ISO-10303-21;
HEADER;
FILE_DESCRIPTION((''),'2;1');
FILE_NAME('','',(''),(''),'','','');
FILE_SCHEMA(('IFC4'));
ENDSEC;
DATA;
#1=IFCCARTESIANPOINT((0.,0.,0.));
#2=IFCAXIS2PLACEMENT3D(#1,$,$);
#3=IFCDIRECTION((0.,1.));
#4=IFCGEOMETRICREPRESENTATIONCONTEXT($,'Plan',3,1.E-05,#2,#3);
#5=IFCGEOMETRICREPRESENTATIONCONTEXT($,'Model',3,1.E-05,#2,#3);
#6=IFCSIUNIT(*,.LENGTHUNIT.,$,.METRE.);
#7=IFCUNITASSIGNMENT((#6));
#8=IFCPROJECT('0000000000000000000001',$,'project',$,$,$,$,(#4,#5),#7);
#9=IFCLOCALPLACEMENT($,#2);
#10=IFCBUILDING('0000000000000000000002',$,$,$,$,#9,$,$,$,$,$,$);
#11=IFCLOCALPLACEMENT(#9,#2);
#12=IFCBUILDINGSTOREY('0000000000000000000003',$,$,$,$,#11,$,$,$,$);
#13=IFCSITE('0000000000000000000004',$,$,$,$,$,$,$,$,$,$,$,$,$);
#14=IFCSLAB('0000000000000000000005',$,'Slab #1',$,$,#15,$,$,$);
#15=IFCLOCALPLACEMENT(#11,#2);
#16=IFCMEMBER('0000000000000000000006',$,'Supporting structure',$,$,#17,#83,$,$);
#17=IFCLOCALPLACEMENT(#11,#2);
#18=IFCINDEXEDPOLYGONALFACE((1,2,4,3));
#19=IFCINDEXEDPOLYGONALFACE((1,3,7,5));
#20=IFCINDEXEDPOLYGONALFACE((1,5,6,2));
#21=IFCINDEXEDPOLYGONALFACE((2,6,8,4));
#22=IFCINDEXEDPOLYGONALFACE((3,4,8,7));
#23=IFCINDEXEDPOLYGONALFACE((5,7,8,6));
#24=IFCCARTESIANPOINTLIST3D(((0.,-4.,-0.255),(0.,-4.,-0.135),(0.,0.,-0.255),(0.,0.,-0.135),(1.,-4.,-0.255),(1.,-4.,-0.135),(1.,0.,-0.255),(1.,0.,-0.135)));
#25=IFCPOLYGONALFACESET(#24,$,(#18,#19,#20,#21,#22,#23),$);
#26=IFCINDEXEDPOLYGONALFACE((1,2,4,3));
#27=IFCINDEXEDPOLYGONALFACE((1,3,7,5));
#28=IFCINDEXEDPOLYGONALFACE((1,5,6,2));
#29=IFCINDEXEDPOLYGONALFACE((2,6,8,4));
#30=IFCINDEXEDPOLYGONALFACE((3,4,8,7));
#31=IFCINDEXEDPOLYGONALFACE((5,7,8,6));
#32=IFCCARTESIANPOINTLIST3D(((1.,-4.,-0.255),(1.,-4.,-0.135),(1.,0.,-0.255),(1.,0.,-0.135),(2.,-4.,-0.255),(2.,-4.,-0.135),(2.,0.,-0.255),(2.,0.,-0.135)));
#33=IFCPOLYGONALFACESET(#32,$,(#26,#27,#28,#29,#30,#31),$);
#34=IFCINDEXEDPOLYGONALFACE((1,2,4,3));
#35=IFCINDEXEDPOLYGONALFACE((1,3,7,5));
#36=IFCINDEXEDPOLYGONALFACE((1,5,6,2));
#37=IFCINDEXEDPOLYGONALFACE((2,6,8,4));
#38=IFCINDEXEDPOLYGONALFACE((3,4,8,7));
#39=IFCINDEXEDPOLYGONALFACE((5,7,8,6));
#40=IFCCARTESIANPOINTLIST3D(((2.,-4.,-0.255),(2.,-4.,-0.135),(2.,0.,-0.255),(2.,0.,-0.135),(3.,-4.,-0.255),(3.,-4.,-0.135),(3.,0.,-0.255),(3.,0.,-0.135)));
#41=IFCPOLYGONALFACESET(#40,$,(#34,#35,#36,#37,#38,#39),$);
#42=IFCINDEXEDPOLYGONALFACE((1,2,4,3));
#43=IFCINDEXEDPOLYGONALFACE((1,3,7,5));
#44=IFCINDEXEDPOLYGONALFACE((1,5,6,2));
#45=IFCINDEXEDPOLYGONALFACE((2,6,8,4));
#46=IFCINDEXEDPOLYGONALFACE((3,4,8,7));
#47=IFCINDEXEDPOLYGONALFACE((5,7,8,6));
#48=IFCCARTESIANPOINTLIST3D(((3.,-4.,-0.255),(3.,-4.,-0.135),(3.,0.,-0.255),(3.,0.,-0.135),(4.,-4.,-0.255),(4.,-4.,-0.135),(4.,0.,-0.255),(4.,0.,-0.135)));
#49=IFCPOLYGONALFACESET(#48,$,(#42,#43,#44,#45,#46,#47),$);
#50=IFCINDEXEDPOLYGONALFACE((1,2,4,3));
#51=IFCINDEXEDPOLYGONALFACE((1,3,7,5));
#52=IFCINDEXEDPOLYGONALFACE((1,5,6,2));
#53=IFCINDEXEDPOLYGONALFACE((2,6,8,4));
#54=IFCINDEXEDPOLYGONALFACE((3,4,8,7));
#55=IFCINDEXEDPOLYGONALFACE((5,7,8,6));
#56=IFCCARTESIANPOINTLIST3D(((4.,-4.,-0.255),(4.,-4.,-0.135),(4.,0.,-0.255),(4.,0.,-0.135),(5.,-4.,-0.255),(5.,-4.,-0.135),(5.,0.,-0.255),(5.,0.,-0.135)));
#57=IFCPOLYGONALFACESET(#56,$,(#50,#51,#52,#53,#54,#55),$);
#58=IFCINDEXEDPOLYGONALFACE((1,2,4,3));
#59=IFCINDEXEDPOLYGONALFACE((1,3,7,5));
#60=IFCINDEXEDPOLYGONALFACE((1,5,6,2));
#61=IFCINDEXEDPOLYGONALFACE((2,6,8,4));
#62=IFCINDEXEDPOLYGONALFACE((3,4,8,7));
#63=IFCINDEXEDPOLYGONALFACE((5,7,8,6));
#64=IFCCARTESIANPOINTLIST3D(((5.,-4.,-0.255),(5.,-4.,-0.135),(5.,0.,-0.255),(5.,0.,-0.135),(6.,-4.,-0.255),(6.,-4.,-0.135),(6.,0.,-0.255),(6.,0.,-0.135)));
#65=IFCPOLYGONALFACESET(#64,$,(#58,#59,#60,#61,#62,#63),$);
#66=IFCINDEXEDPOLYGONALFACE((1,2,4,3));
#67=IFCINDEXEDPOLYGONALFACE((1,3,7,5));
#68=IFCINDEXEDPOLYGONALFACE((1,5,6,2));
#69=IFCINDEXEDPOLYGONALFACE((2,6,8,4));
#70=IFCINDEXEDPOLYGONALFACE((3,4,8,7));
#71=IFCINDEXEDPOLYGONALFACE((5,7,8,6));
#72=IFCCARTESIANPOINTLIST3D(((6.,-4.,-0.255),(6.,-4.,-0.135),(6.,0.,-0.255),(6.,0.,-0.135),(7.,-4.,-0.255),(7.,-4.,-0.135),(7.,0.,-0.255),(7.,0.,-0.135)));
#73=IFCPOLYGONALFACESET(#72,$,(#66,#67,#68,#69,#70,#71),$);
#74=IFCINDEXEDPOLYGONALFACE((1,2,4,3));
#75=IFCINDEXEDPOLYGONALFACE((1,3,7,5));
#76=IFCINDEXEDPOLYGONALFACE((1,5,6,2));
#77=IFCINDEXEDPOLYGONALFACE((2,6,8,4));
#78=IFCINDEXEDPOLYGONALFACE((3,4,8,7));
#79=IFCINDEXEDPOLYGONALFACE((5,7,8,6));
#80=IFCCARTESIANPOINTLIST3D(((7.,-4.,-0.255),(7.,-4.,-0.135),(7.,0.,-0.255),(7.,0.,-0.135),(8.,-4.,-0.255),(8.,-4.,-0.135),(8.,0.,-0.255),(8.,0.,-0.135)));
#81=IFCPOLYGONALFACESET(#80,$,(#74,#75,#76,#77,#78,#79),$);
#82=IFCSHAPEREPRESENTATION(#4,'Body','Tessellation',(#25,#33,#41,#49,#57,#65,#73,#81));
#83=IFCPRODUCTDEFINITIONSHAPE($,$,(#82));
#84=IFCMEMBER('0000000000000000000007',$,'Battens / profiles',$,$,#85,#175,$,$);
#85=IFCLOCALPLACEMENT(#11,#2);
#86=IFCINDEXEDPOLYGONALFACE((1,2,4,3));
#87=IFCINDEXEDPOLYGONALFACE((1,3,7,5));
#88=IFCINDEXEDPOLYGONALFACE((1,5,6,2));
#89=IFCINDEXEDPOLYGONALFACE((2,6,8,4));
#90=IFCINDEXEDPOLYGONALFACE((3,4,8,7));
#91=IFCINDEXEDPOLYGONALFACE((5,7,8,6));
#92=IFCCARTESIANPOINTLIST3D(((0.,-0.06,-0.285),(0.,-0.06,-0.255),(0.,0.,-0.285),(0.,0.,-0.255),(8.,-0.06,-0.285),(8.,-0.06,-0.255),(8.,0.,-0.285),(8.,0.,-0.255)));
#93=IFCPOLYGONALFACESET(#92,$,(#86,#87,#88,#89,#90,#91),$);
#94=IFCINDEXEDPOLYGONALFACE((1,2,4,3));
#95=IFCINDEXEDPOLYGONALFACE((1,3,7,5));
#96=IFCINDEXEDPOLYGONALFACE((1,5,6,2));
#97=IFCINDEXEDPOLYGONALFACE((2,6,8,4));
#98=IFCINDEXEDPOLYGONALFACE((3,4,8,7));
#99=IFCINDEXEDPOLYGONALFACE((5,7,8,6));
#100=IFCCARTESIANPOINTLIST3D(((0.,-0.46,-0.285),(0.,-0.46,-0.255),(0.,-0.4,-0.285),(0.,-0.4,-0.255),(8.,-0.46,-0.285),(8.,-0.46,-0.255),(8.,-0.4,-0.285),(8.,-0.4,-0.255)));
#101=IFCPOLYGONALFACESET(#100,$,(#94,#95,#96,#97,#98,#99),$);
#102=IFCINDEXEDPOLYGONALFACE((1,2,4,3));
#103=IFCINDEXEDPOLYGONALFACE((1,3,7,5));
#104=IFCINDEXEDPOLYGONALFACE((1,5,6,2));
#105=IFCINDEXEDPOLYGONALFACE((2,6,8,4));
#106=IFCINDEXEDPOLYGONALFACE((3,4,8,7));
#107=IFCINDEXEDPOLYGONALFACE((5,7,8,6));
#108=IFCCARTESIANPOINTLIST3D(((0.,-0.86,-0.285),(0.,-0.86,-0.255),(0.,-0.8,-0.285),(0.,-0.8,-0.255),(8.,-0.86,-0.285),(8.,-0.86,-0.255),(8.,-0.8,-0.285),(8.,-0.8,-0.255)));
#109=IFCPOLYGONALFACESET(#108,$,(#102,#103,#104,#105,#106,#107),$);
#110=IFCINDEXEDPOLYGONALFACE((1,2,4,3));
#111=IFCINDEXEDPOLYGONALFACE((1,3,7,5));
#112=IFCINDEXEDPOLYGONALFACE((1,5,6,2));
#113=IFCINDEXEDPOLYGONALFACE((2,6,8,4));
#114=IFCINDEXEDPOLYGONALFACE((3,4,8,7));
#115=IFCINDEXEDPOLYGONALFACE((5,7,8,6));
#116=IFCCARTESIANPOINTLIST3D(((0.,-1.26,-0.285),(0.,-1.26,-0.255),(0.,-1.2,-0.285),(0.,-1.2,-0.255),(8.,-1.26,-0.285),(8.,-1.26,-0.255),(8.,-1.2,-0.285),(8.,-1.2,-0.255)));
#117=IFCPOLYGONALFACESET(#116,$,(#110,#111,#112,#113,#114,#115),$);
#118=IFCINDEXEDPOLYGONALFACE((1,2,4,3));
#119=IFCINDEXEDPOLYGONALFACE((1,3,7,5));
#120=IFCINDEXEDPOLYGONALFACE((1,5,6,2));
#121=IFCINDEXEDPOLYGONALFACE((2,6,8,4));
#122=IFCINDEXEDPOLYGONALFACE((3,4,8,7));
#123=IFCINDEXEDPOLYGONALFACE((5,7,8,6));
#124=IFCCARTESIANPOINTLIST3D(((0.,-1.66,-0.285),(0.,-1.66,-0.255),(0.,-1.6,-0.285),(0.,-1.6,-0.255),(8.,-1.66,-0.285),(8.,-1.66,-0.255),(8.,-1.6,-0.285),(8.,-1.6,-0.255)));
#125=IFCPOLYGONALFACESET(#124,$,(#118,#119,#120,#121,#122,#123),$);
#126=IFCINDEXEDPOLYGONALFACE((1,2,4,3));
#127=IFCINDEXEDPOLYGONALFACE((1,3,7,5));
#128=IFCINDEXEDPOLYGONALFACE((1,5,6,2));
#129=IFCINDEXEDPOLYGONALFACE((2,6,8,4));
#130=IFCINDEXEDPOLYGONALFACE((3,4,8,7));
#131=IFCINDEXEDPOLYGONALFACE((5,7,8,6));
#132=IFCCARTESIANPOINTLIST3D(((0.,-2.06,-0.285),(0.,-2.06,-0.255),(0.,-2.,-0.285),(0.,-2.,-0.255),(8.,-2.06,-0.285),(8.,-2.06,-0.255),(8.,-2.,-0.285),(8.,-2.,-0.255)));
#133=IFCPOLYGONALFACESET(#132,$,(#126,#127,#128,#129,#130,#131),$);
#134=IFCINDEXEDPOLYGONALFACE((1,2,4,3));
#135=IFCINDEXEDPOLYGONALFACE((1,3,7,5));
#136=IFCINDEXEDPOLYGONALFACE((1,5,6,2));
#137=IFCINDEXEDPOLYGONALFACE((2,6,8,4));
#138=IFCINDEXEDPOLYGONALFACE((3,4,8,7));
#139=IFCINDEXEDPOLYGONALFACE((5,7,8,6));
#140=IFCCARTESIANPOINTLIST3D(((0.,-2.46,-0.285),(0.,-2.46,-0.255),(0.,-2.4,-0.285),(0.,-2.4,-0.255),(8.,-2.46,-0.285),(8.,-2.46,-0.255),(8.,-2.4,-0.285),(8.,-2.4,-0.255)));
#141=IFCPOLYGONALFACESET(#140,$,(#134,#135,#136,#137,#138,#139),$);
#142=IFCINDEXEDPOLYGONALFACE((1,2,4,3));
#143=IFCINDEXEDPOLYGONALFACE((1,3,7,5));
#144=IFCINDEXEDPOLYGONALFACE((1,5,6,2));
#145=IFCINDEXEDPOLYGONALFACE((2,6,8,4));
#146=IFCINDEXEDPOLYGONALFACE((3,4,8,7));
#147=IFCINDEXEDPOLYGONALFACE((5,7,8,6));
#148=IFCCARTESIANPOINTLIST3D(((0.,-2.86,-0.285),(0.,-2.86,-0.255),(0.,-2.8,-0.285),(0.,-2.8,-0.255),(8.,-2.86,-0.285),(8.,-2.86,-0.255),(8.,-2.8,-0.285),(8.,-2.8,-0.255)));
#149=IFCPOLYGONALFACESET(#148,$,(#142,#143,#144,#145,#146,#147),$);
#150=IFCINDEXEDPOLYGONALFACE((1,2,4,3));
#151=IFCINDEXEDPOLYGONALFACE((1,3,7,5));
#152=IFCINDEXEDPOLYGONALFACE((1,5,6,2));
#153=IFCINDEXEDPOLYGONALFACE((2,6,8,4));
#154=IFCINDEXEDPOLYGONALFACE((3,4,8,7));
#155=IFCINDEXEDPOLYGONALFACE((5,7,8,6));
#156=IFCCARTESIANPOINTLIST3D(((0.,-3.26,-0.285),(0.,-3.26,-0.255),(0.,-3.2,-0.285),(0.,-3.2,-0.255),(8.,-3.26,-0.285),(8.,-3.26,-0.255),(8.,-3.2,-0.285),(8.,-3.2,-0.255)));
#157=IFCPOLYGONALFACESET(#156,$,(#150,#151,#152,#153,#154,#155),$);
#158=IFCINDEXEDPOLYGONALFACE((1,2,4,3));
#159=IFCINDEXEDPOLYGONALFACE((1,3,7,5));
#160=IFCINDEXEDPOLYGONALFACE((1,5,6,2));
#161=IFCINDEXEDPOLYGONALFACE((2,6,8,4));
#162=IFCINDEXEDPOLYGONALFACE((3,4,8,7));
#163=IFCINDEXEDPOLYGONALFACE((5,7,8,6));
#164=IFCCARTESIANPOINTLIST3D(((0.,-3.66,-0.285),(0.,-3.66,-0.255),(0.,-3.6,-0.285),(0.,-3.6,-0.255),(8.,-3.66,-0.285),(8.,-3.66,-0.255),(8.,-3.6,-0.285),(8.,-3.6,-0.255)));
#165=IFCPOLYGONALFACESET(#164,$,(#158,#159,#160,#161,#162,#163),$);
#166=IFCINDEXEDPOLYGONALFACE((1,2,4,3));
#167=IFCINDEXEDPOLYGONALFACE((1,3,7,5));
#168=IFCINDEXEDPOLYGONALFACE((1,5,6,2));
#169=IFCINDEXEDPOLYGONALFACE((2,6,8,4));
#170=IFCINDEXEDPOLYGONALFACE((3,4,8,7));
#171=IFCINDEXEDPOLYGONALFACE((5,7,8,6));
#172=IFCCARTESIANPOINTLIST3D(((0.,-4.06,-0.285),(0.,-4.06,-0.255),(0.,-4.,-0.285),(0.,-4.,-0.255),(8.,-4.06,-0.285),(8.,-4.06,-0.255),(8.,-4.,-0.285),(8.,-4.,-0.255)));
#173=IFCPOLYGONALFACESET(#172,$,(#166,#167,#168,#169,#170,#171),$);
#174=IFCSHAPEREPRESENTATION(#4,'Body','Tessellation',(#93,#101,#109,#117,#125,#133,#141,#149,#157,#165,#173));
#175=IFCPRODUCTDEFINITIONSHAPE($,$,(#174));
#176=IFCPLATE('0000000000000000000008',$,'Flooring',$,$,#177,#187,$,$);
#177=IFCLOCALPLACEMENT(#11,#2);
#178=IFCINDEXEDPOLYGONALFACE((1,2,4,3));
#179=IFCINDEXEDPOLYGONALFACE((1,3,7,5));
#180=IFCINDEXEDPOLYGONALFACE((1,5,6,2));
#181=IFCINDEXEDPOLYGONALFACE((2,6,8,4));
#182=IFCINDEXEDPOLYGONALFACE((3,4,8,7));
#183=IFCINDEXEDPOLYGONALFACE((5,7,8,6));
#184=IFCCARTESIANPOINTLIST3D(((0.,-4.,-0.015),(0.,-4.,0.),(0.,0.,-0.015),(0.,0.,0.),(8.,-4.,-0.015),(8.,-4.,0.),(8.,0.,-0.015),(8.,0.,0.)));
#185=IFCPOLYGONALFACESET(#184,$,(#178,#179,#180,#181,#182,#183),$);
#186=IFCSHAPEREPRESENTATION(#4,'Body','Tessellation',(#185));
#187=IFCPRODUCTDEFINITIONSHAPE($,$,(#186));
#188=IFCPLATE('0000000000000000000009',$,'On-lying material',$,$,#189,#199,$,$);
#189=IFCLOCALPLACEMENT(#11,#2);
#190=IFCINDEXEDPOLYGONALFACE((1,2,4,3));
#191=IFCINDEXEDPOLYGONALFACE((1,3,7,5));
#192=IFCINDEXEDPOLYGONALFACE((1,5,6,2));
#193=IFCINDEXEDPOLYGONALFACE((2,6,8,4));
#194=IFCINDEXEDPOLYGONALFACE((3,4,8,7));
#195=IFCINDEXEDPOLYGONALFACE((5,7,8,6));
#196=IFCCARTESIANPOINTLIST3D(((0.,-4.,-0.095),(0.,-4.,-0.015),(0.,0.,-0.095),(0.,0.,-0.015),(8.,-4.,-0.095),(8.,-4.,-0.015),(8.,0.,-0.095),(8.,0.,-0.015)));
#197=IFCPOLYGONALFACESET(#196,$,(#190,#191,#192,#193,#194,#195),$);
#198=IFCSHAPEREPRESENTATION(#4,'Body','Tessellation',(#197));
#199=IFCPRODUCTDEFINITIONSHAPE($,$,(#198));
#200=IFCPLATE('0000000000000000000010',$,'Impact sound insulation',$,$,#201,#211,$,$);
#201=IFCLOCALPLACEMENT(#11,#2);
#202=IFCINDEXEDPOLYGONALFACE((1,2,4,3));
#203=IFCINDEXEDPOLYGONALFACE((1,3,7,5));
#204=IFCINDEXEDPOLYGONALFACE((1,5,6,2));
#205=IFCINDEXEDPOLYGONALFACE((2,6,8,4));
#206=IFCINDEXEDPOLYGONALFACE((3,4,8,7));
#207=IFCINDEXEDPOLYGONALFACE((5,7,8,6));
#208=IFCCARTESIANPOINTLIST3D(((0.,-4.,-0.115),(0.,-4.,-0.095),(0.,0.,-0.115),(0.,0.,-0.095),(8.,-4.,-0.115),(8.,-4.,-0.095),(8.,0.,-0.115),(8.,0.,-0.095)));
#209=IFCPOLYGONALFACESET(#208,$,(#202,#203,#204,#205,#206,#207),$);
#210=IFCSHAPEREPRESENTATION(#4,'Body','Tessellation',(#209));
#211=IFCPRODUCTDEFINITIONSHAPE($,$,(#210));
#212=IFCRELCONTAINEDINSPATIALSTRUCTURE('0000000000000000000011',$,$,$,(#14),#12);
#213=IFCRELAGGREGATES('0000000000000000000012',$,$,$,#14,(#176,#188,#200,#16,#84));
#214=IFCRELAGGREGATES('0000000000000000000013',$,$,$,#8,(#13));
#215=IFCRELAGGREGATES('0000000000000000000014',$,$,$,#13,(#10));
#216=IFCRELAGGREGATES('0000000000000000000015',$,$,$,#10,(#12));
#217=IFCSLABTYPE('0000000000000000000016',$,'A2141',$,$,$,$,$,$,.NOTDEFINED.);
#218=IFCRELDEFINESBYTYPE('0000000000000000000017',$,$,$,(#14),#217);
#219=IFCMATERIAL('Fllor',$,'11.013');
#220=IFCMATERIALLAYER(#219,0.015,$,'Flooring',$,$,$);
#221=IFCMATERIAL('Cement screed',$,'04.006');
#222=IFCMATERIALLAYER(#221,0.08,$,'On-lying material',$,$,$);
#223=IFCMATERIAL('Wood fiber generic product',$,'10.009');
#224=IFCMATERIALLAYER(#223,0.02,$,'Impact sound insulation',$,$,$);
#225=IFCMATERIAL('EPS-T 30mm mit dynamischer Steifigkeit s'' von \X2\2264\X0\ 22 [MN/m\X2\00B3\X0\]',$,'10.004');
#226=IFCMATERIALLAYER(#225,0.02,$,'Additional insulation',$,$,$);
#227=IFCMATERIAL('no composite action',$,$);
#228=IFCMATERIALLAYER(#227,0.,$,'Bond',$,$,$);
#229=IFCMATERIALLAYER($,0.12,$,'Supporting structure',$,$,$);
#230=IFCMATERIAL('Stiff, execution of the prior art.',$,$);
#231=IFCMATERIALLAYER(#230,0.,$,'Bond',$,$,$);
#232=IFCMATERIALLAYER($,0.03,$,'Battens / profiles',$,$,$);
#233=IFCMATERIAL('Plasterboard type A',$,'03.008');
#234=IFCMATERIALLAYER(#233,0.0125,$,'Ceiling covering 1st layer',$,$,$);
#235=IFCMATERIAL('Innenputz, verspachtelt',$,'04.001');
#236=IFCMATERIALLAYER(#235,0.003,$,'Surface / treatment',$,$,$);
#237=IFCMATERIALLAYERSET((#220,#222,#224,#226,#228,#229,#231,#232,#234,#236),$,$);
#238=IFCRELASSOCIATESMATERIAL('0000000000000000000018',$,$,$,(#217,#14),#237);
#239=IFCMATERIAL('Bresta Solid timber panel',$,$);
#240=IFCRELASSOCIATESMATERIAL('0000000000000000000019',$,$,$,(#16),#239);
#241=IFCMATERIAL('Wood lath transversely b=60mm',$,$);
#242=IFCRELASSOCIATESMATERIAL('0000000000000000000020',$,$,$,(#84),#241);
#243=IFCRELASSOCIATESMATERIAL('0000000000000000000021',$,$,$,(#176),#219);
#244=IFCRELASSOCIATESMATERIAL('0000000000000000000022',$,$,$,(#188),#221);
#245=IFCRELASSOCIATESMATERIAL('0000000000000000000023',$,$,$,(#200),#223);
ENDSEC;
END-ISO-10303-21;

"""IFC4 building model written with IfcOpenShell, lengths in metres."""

from ifc_helpers import new_model, si_unit, direction, frame, frame_2d, origin, origin_with_axes, place, context, project, spatial, rectangle, extrude, material, layer, layer_set, type_object, element, aggregate, save


model = new_model("IFC4")

# Units and contexts
plan_context = context("Plan", 3, precision=1e-05, world=origin(), true_north=direction((0.0, 1.0)))
model_context = context("Model", 3, precision=1e-05, world=origin(), true_north=direction((0.0, 1.0)))
ifc_project = project(units=[si_unit("LENGTHUNIT", "METRE")], contexts=[plan_context, model_context])

# Site, building, storey
site = spatial("IfcSite", under=ifc_project)
building_placement = place(None, origin())
building = spatial("IfcBuilding", under=site, at=building_placement)
storey_placement = place(building_placement, origin())
storey = spatial("IfcBuildingStorey", under=building, at=storey_placement)

# Slab, members, plates
ifc_material_1 = material(Name="Fllor", Category="11.013")
ifc_layer_1 = layer(ifc_material_1, 0.015, Name="Flooring")
ifc_material_2 = material(Name="Cement screed", Category="04.006")
ifc_layer_2 = layer(ifc_material_2, 0.08, Name="On-lying material")
ifc_material_3 = material(Name="Wood fiber generic product", Category="10.009")
ifc_layer_3 = layer(ifc_material_3, 0.02, Name="Impact sound insulation")
ifc_material_4 = material(Name="EPS-T 30mm mit dynamischer Steifigkeit s' von ≤ 22 [MN/m³]", Category="10.004")
ifc_layer_4 = layer(ifc_material_4, 0.02, Name="Additional insulation")
ifc_material_5 = material(Name="no composite action")
ifc_layer_5 = layer(ifc_material_5, 0.0, Name="Bond")
ifc_layer_6 = layer(None, 0.12, Name="Supporting structure")
ifc_material_6 = material(Name="Stiff, execution of the prior art.")
ifc_layer_7 = layer(ifc_material_6, 0.0, Name="Bond")
ifc_layer_8 = layer(None, 0.03, Name="Battens / profiles")
ifc_material_7 = material(Name="Plasterboard type A", Category="03.008")
ifc_layer_9 = layer(ifc_material_7, 0.0125, Name="Ceiling covering 1st layer")
ifc_material_8 = material(Name="Innenputz, verspachtelt", Category="04.001")
ifc_layer_10 = layer(ifc_material_8, 0.003, Name="Surface / treatment")
ifc_layer_set = layer_set([ifc_layer_1, ifc_layer_2, ifc_layer_3, ifc_layer_4, ifc_layer_5, ifc_layer_6, ifc_layer_7, ifc_layer_8, ifc_layer_9, ifc_layer_10])
slab_type = type_object("IfcSlabType", Name="A2141", PredefinedType="NOTDEFINED", material=ifc_layer_set)
slab_placement = place(None, frame((0.0, 0.0, 0.0), z_axis=(0.0, 0.0, -1.0), x_axis=(1.0, 0.0, 0.0)))
slab = element("IfcSlab", 1, at=slab_placement, inside=storey, type_object=slab_type, material=ifc_layer_set, Name="Slab #1")
ifc_material_9 = material(Name="Bresta Solid timber panel")
member_1_placement = place(slab_placement, origin())
member_1 = element("IfcMember", 2, at=member_1_placement, material=ifc_material_9, Name="Supporting structure", context=plan_context, shape_type="SweptSolid", body=[
    extrude(rectangle(XDim=1.0, YDim=0.12, at=frame_2d((0.5, 0.06), x_axis=(1.0, 0.0))), frame((0.0, 4.0, 0.135), z_axis=(0.0, -1.0, 0.0), x_axis=(1.0, 0.0, 0.0)), (0.0, 0.0, 1.0), 4.0),
    extrude(rectangle(XDim=1.0, YDim=0.12, at=frame_2d((0.5, 0.06), x_axis=(1.0, 0.0))), frame((1.0, 4.0, 0.135), z_axis=(0.0, -1.0, 0.0), x_axis=(1.0, 0.0, 0.0)), (0.0, 0.0, 1.0), 4.0),
    extrude(rectangle(XDim=1.0, YDim=0.12, at=frame_2d((0.5, 0.06), x_axis=(1.0, 0.0))), frame((2.0, 4.0, 0.135), z_axis=(0.0, -1.0, 0.0), x_axis=(1.0, 0.0, 0.0)), (0.0, 0.0, 1.0), 4.0),
    extrude(rectangle(XDim=1.0, YDim=0.12, at=frame_2d((0.5, 0.06), x_axis=(1.0, 0.0))), frame((3.0, 4.0, 0.135), z_axis=(0.0, -1.0, 0.0), x_axis=(1.0, 0.0, 0.0)), (0.0, 0.0, 1.0), 4.0),
    extrude(rectangle(XDim=1.0, YDim=0.12, at=frame_2d((0.5, 0.06), x_axis=(1.0, 0.0))), frame((4.0, 4.0, 0.135), z_axis=(0.0, -1.0, 0.0), x_axis=(1.0, 0.0, 0.0)), (0.0, 0.0, 1.0), 4.0),
    extrude(rectangle(XDim=1.0, YDim=0.12, at=frame_2d((0.5, 0.06), x_axis=(1.0, 0.0))), frame((5.0, 4.0, 0.135), z_axis=(0.0, -1.0, 0.0), x_axis=(1.0, 0.0, 0.0)), (0.0, 0.0, 1.0), 4.0),
    extrude(rectangle(XDim=1.0, YDim=0.12, at=frame_2d((0.5, 0.06), x_axis=(1.0, 0.0))), frame((6.0, 4.0, 0.135), z_axis=(0.0, -1.0, 0.0), x_axis=(1.0, 0.0, 0.0)), (0.0, 0.0, 1.0), 4.0),
    extrude(rectangle(XDim=1.0, YDim=0.12, at=frame_2d((0.5, 0.06), x_axis=(1.0, 0.0))), frame((7.0, 4.0, 0.135), z_axis=(0.0, -1.0, 0.0), x_axis=(1.0, 0.0, 0.0)), (0.0, 0.0, 1.0), 4.0),
])
ifc_material_10 = material(Name="Wood lath transversely b=60mm")
member_2_placement = place(slab_placement, origin())
member_2 = element("IfcMember", 3, at=member_2_placement, material=ifc_material_10, Name="Battens / profiles", context=plan_context, shape_type="SweptSolid", body=[
    extrude(rectangle(XDim=0.06, YDim=0.03, at=frame_2d((0.03, 0.015), x_axis=(1.0, 0.0))), frame((0.0, 0.0, 0.255), z_axis=(1.0, 0.0, 0.0), x_axis=(0.0, 1.0, 0.0)), (0.0, 0.0, 1.0), 8.0),
    extrude(rectangle(XDim=0.06, YDim=0.03, at=frame_2d((0.03, 0.015), x_axis=(1.0, 0.0))), frame((0.0, 0.4, 0.255), z_axis=(1.0, 0.0, 0.0), x_axis=(0.0, 1.0, 0.0)), (0.0, 0.0, 1.0), 8.0),
    extrude(rectangle(XDim=0.06, YDim=0.03, at=frame_2d((0.03, 0.015), x_axis=(1.0, 0.0))), frame((0.0, 0.8, 0.255), z_axis=(1.0, 0.0, 0.0), x_axis=(0.0, 1.0, 0.0)), (0.0, 0.0, 1.0), 8.0),
    extrude(rectangle(XDim=0.06, YDim=0.03, at=frame_2d((0.03, 0.015), x_axis=(1.0, 0.0))), frame((0.0, 1.2, 0.255), z_axis=(1.0, 0.0, 0.0), x_axis=(0.0, 1.0, 0.0)), (0.0, 0.0, 1.0), 8.0),
    extrude(rectangle(XDim=0.06, YDim=0.03, at=frame_2d((0.03, 0.015), x_axis=(1.0, 0.0))), frame((0.0, 1.6, 0.255), z_axis=(1.0, 0.0, 0.0), x_axis=(0.0, 1.0, 0.0)), (0.0, 0.0, 1.0), 8.0),
    extrude(rectangle(XDim=0.06, YDim=0.03, at=frame_2d((0.03, 0.015), x_axis=(1.0, 0.0))), frame((0.0, 2.0, 0.255), z_axis=(1.0, 0.0, 0.0), x_axis=(0.0, 1.0, 0.0)), (0.0, 0.0, 1.0), 8.0),
    extrude(rectangle(XDim=0.06, YDim=0.03, at=frame_2d((0.03, 0.015), x_axis=(1.0, 0.0))), frame((0.0, 2.4, 0.255), z_axis=(1.0, 0.0, 0.0), x_axis=(0.0, 1.0, 0.0)), (0.0, 0.0, 1.0), 8.0),
    extrude(rectangle(XDim=0.06, YDim=0.03, at=frame_2d((0.03, 0.015), x_axis=(1.0, 0.0))), frame((0.0, 2.8, 0.255), z_axis=(1.0, 0.0, 0.0), x_axis=(0.0, 1.0, 0.0)), (0.0, 0.0, 1.0), 8.0),
    extrude(rectangle(XDim=0.06, YDim=0.03, at=frame_2d((0.03, 0.015), x_axis=(1.0, 0.0))), frame((0.0, 3.2, 0.255), z_axis=(1.0, 0.0, 0.0), x_axis=(0.0, 1.0, 0.0)), (0.0, 0.0, 1.0), 8.0),
    extrude(rectangle(XDim=0.06, YDim=0.03, at=frame_2d((0.03, 0.015), x_axis=(1.0, 0.0))), frame((0.0, 3.6, 0.255), z_axis=(1.0, 0.0, 0.0), x_axis=(0.0, 1.0, 0.0)), (0.0, 0.0, 1.0), 8.0),
    extrude(rectangle(XDim=0.06, YDim=0.03, at=frame_2d((0.03, 0.015), x_axis=(1.0, 0.0))), frame((0.0, 4.0, 0.255), z_axis=(1.0, 0.0, 0.0), x_axis=(0.0, 1.0, 0.0)), (0.0, 0.0, 1.0), 8.0),
])
plate_1_placement = place(slab_placement, origin())
plate_1 = element("IfcPlate", 4, at=plate_1_placement, material=ifc_material_1, Name="Flooring", context=plan_context, shape_type="SweptSolid", body=[
    extrude(rectangle(XDim=8.0, YDim=4.0, at=frame_2d((4.0, 2.0), x_axis=(1.0, 0.0))), origin_with_axes(), (0.0, 0.0, 1.0), 0.015),
])
plate_2_placement = place(slab_placement, origin())
plate_2 = element("IfcPlate", 5, at=plate_2_placement, material=ifc_material_2, Name="On-lying material", context=plan_context, shape_type="SweptSolid", body=[
    extrude(rectangle(XDim=8.0, YDim=4.0, at=frame_2d((4.0, 2.0), x_axis=(1.0, 0.0))), frame((0.0, 0.0, 0.015), z_axis=(0.0, 0.0, 1.0), x_axis=(1.0, 0.0, 0.0)), (0.0, 0.0, 1.0), 0.08),
])
plate_3_placement = place(slab_placement, origin())
plate_3 = element("IfcPlate", 6, at=plate_3_placement, material=ifc_material_3, Name="Impact sound insulation", context=plan_context, shape_type="SweptSolid", body=[
    extrude(rectangle(XDim=8.0, YDim=4.0, at=frame_2d((4.0, 2.0), x_axis=(1.0, 0.0))), frame((0.0, 0.0, 0.095), z_axis=(0.0, 0.0, 1.0), x_axis=(1.0, 0.0, 0.0)), (0.0, 0.0, 1.0), 0.02),
])
aggregate(slab, [plate_1, plate_2, plate_3, member_1, member_2])

save(model, "model.ifc")
